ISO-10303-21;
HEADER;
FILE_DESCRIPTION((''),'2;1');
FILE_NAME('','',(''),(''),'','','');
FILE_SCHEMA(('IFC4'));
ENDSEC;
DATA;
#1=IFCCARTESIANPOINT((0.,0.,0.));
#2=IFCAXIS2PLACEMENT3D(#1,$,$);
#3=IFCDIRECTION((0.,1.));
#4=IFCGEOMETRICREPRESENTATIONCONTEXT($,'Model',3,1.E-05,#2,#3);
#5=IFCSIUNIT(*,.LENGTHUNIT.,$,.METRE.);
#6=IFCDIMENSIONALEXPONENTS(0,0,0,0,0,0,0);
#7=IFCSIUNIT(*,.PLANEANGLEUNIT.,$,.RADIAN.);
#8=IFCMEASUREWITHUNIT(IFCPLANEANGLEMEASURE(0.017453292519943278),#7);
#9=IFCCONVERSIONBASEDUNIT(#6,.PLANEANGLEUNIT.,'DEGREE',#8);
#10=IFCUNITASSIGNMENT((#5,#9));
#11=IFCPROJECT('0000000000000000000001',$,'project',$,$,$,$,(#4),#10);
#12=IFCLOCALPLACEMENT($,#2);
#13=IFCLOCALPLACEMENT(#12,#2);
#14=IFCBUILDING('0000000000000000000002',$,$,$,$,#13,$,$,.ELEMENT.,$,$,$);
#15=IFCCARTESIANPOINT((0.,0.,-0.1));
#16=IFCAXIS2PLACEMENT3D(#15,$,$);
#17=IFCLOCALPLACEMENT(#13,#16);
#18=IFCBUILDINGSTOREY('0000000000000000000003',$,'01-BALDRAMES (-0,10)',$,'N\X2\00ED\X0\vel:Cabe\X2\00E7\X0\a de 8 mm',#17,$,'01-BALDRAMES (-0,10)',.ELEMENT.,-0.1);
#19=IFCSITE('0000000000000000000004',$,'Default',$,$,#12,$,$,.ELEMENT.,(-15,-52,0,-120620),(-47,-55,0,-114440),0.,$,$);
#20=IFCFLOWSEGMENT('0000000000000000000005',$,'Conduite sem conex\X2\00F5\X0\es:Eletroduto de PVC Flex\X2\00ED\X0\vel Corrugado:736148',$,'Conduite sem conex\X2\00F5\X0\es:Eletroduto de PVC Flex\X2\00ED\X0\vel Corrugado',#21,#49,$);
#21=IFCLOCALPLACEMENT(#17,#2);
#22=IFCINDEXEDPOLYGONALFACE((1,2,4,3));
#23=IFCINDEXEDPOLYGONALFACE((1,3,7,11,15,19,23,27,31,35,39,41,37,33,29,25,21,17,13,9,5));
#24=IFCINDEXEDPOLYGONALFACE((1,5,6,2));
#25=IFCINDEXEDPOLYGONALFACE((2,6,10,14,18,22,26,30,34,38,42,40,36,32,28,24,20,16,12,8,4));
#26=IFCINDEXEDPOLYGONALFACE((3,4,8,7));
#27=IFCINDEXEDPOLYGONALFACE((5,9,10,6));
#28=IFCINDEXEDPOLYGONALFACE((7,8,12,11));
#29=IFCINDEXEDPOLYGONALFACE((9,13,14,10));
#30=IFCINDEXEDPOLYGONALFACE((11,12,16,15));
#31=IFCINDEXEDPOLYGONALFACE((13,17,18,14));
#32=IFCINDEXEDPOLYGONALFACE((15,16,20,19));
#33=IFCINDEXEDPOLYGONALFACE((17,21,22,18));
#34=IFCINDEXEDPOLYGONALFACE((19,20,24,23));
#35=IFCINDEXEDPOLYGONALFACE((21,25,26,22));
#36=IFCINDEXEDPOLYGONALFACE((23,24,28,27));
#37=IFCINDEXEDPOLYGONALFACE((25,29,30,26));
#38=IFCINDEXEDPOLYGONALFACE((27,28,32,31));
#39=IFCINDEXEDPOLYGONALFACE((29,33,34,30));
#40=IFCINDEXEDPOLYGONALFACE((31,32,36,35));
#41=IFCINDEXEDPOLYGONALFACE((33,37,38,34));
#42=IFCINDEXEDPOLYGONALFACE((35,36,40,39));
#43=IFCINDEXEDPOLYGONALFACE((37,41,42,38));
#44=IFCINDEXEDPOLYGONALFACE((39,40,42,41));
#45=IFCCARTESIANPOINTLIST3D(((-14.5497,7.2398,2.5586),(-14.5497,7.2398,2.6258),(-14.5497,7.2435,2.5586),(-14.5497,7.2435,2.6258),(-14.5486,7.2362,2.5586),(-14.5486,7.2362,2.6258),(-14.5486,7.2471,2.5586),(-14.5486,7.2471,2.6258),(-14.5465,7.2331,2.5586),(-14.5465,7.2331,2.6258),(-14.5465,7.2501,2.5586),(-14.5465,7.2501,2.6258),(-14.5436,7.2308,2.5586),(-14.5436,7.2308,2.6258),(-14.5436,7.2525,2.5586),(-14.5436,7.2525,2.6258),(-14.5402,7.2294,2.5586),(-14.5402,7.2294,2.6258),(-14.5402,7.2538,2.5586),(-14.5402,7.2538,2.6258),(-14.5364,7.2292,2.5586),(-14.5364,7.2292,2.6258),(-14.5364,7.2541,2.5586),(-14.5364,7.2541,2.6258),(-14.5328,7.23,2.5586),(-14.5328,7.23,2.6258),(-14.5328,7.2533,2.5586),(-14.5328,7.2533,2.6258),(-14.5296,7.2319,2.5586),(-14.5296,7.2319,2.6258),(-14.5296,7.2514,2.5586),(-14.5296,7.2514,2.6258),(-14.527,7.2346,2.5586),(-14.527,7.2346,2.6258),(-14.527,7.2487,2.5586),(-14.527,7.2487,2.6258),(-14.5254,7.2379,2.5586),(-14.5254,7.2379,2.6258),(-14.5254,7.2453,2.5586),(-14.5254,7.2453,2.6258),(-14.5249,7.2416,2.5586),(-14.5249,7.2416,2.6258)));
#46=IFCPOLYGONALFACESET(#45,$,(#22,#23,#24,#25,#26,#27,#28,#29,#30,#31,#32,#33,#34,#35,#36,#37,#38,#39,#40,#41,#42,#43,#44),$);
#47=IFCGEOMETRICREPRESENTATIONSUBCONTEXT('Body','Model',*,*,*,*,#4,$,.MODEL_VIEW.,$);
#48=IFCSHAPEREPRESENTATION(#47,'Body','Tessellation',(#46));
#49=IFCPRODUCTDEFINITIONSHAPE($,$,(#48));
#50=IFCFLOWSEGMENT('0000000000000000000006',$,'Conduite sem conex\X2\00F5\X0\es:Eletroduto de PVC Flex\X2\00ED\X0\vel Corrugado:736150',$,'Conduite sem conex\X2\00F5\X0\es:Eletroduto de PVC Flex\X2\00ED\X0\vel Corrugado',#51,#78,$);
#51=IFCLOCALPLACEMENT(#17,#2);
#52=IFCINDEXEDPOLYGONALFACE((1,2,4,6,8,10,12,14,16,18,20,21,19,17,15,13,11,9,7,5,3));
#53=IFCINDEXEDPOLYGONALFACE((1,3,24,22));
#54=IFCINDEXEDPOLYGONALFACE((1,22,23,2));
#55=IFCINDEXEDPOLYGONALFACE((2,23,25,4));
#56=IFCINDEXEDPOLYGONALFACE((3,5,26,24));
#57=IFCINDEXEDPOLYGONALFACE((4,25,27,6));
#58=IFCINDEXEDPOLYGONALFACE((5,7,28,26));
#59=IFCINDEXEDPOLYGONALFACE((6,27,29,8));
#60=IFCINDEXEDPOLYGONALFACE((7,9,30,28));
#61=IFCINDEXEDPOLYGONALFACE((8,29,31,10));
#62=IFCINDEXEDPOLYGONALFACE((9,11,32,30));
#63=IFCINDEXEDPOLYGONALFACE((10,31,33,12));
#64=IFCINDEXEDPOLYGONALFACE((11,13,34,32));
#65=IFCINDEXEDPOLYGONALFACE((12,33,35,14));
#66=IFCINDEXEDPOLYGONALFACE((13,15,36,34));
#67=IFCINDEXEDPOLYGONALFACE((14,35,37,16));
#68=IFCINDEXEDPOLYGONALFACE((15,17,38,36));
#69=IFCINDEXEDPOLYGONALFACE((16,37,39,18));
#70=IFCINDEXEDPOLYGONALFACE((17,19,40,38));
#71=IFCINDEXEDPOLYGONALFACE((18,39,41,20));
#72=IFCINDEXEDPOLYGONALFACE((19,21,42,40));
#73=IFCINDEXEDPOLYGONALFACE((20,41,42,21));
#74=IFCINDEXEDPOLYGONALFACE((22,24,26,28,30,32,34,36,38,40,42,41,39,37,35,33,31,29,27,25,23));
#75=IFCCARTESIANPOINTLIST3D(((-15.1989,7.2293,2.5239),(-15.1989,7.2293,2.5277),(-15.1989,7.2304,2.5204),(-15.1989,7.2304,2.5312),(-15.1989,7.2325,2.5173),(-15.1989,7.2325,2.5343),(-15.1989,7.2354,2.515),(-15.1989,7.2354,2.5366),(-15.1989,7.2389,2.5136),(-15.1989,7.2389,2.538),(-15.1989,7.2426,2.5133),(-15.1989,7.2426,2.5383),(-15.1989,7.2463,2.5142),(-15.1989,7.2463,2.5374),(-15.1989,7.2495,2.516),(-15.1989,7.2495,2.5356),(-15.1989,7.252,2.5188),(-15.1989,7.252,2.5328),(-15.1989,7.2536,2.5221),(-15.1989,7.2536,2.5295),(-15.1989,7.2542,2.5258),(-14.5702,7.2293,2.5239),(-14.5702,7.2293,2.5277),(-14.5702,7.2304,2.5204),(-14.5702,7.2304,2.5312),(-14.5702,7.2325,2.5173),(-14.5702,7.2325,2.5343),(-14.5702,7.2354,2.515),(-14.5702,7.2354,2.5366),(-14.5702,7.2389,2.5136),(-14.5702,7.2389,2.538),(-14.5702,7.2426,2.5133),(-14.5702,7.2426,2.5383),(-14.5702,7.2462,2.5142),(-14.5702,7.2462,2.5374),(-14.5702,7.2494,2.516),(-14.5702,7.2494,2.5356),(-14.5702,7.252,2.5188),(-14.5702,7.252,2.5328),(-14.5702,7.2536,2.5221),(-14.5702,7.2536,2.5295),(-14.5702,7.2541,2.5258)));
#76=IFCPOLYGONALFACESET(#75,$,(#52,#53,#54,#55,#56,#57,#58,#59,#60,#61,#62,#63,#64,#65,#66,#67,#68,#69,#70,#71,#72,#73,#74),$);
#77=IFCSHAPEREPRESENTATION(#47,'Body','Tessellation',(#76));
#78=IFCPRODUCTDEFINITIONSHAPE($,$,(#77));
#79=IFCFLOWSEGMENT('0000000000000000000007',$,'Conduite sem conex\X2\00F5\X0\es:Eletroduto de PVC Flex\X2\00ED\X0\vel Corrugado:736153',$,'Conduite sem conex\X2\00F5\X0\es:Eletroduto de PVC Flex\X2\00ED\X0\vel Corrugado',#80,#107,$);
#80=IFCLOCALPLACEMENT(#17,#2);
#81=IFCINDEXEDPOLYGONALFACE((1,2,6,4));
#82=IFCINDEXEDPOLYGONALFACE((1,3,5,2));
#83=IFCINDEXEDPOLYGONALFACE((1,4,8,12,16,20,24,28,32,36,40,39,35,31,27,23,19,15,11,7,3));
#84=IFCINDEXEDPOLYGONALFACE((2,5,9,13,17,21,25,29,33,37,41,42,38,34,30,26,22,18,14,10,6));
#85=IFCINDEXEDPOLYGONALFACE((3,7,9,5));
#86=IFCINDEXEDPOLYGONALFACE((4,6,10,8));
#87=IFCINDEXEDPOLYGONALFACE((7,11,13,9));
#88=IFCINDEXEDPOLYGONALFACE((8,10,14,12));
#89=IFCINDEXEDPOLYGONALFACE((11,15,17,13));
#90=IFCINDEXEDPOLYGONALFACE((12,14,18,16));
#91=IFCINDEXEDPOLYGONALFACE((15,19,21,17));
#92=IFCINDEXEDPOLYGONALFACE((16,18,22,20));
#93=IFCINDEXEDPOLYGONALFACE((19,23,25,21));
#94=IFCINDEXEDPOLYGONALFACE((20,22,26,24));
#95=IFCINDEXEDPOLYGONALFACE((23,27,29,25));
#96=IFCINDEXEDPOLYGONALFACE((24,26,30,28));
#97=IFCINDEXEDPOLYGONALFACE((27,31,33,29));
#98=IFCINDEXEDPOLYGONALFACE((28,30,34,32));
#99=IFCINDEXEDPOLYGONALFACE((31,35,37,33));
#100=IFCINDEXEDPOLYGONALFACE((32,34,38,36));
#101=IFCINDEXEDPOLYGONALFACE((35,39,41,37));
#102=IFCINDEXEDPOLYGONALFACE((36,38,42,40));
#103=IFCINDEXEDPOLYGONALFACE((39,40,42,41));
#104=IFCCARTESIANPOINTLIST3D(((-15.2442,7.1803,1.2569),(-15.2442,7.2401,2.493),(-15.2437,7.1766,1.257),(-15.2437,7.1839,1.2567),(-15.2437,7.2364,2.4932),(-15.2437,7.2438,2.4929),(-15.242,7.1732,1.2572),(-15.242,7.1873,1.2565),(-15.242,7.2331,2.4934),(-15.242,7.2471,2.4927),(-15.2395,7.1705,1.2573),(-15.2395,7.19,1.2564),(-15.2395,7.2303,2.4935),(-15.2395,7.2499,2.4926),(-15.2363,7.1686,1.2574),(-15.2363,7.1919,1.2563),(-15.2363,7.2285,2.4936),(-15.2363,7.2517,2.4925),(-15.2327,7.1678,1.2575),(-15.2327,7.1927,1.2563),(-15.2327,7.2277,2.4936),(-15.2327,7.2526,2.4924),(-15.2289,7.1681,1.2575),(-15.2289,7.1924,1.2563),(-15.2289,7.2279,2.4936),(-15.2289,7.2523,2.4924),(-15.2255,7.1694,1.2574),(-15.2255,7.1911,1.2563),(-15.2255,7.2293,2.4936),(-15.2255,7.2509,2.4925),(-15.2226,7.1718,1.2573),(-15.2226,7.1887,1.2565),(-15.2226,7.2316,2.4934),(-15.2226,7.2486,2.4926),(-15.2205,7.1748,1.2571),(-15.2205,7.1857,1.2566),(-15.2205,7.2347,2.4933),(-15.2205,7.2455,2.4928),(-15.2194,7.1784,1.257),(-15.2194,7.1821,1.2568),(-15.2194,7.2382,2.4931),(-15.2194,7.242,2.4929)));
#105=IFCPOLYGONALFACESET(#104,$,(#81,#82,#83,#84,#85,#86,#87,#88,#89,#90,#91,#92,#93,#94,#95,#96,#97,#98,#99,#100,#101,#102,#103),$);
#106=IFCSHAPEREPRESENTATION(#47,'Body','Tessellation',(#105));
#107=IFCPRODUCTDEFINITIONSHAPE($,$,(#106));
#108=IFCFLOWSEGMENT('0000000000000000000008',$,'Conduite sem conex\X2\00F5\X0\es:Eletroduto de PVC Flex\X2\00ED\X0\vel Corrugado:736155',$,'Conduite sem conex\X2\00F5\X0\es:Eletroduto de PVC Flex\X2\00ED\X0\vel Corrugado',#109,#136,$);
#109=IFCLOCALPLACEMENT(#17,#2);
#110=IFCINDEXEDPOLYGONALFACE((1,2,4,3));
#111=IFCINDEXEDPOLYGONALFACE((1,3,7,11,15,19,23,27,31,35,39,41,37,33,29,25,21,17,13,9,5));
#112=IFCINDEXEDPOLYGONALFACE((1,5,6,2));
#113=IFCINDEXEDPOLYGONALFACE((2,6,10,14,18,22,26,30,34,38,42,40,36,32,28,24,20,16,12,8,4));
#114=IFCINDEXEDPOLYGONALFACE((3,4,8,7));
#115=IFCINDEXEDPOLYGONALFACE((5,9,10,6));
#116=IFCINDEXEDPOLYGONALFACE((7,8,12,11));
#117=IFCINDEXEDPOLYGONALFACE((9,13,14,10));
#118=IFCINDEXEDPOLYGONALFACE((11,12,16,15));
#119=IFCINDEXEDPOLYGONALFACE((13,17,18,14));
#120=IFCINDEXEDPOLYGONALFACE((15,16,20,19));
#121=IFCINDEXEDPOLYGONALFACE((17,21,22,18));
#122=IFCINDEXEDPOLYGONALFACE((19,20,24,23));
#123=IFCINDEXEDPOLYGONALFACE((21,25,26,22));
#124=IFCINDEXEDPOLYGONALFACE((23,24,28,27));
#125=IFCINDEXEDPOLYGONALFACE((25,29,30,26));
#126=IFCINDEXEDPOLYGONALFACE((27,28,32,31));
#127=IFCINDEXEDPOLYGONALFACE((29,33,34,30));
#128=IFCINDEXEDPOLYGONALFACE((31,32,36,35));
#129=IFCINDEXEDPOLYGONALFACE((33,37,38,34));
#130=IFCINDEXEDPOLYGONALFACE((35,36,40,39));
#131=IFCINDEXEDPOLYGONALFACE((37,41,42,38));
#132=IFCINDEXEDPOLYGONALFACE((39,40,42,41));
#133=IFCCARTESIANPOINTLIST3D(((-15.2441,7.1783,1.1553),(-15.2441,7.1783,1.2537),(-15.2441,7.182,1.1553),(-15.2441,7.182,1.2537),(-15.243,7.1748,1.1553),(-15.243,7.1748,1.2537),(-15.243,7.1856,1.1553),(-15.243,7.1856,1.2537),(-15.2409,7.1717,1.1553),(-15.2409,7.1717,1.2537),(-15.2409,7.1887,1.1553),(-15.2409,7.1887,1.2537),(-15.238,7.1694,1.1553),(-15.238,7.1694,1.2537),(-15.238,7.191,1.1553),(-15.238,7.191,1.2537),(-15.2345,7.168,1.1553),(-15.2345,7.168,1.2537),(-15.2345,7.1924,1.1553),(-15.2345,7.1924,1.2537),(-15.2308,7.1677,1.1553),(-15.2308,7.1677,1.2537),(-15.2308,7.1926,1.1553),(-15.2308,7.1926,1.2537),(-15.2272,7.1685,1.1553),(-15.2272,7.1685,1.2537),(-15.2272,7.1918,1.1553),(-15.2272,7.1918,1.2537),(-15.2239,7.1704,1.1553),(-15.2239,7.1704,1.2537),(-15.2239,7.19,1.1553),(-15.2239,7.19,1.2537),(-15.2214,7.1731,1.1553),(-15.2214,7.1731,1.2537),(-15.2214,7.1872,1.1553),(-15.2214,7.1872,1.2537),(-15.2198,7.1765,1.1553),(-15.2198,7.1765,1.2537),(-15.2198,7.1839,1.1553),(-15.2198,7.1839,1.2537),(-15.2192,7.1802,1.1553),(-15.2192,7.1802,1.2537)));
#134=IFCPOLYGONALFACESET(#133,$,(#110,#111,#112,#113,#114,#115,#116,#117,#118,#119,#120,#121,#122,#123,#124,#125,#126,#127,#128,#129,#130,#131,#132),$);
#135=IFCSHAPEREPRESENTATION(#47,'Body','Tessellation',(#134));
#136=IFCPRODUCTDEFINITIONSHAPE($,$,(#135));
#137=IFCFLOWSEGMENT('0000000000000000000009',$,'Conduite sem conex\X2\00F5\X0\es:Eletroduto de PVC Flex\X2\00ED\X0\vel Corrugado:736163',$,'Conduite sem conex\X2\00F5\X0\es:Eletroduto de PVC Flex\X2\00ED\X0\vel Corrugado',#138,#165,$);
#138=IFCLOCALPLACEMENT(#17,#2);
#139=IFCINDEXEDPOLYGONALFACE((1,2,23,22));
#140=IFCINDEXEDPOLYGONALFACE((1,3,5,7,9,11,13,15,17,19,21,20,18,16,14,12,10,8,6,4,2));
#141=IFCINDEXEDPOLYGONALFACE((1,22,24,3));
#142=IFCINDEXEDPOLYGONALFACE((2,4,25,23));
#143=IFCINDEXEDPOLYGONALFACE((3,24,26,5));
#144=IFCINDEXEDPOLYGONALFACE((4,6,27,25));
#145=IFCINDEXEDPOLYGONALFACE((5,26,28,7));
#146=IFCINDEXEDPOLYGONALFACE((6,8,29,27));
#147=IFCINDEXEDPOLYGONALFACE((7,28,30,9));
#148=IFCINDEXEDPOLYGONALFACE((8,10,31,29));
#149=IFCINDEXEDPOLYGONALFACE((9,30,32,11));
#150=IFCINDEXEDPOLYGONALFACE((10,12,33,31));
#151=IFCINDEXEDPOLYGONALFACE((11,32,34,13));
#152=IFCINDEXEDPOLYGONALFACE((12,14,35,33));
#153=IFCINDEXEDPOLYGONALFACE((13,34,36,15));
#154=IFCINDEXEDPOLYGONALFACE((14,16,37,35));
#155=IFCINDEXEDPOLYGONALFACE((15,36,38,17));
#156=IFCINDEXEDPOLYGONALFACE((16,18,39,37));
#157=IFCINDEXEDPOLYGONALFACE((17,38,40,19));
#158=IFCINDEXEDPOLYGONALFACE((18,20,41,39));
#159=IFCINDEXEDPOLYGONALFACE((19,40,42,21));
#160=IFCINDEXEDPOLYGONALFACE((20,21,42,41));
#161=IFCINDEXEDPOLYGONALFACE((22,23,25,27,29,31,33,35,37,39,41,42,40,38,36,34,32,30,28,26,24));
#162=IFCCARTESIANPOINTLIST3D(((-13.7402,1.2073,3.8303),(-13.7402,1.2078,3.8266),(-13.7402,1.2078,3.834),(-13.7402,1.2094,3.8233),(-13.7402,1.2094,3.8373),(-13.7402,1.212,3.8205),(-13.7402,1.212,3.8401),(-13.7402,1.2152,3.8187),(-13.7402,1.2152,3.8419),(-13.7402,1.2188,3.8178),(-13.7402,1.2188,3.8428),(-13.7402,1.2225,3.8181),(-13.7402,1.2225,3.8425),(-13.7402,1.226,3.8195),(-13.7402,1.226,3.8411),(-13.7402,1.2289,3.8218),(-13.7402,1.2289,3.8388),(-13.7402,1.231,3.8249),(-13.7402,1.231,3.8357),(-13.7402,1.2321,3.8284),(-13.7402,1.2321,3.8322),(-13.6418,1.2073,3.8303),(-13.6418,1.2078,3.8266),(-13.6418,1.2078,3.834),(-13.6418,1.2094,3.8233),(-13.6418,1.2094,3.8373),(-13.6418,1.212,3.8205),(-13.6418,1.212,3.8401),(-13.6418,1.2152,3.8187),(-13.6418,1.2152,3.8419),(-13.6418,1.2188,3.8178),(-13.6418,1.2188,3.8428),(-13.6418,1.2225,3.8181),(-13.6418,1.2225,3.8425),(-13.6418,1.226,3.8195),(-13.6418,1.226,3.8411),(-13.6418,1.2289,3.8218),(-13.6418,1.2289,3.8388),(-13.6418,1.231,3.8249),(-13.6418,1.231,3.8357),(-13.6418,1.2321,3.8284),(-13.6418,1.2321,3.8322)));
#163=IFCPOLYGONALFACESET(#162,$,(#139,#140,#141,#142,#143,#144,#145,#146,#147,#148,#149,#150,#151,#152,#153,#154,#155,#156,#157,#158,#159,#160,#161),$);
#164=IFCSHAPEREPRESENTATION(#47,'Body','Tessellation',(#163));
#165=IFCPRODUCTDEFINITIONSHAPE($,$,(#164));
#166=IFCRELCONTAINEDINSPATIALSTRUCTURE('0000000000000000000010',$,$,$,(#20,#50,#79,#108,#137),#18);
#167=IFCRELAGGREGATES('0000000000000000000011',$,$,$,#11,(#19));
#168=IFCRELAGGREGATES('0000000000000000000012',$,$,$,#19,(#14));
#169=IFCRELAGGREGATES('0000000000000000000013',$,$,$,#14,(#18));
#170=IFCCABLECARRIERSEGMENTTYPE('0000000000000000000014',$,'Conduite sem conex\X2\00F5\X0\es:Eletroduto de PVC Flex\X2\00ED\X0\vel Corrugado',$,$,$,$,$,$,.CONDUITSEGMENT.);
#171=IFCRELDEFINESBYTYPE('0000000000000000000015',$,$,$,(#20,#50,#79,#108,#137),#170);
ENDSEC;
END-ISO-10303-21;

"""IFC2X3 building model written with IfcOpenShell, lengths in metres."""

from ifc_helpers import new_model, entity, si_unit, converted_unit, direction, frame, frame_2d, origin, origin_2d_with_axis, place, context, subcontext, project, spatial, circle, extrude, type_object, element, save


model = new_model("IFC2X3")

# Units and contexts
model_context = context("Model", 3, precision=1e-05, world=origin(), true_north=direction((0.0, 1.0)))
body_context = subcontext(model_context, "Body", "Model", "MODEL_VIEW")
ifc_project = project(units=[si_unit("LENGTHUNIT", "METRE"), converted_unit("PLANEANGLEUNIT", "DEGREE", entity("IfcPlaneAngleMeasure", 0.017453292519943278), si_unit("PLANEANGLEUNIT", "RADIAN"), dimensions=[0, 0, 0, 0, 0, 0, 0])], contexts=[model_context])

# Site, building, storey
site_placement = place(None, origin())
site = spatial("IfcSite", under=ifc_project, at=site_placement, Name="Default", CompositionType="ELEMENT", RefLatitude=(-15, -52, 0, -120620), RefLongitude=(-47, -55, 0, -114440), RefElevation=0.0)
building_placement = place(site_placement, origin())
building = spatial("IfcBuilding", under=site, at=building_placement, CompositionType="ELEMENT")
storey_placement = place(building_placement, frame((0.0, 0.0, -0.1)))
storey = spatial("IfcBuildingStorey", under=building, at=storey_placement, Name="01-BALDRAMES (-0,10)", ObjectType="Nível:Cabeça de 8 mm", LongName="01-BALDRAMES (-0,10)", CompositionType="ELEMENT", Elevation=-0.1)

# Flow segments
cable_carrier_segment_type = type_object("IfcCableCarrierSegmentType", Name="Conduite sem conexões:Eletroduto de PVC Flexível Corrugado", PredefinedType="CONDUITSEGMENT")
flow_segment_1_placement = place(storey_placement, origin())
element("IfcFlowSegment", 1, at=flow_segment_1_placement, inside=storey, type_object=cable_carrier_segment_type, Name="Conduite sem conexões:Eletroduto de PVC Flexível Corrugado:736148", ObjectType="Conduite sem conexões:Eletroduto de PVC Flexível Corrugado", context=body_context, shape_type="SweptSolid", body=[
    extrude(circle(Radius=0.0125, at=frame_2d((0.0, 0.0), x_axis=(1.0, 0.0))), frame((-14.5374, 7.2416, 2.5586)), (0.0, 0.0, 1.0), 0.0672),
])
flow_segment_2_placement = place(storey_placement, origin())
element("IfcFlowSegment", 2, at=flow_segment_2_placement, inside=storey, type_object=cable_carrier_segment_type, Name="Conduite sem conexões:Eletroduto de PVC Flexível Corrugado:736150", ObjectType="Conduite sem conexões:Eletroduto de PVC Flexível Corrugado", context=body_context, shape_type="SweptSolid", body=[
    extrude(circle(Radius=0.0125, at=frame_2d((0.0, 0.0), x_axis=(1.0, 0.0))), frame((-15.1989, 7.2417, 2.5258), z_axis=(1.0, -0.000085, 0.0), x_axis=(0.000085, 1.0, 0.0)), (0.0, 0.0, 1.0), 0.6287),
])
flow_segment_3_placement = place(storey_placement, origin())
element("IfcFlowSegment", 3, at=flow_segment_3_placement, inside=storey, type_object=cable_carrier_segment_type, Name="Conduite sem conexões:Eletroduto de PVC Flexível Corrugado:736153", ObjectType="Conduite sem conexões:Eletroduto de PVC Flexível Corrugado", context=body_context, shape_type="SweptSolid", body=[
    extrude(circle(Radius=0.0125, at=frame_2d((0.0, 0.0), x_axis=(1.0, 0.0))), frame((-15.2317, 7.1803, 1.2569), z_axis=(0.0, 0.048359, 0.99883), x_axis=(-1.0, 0.0, 0.0)), (0.0, 0.0, 1.0), 1.2376),
])
flow_segment_4_placement = place(storey_placement, origin())
element("IfcFlowSegment", 4, at=flow_segment_4_placement, inside=storey, type_object=cable_carrier_segment_type, Name="Conduite sem conexões:Eletroduto de PVC Flexível Corrugado:736155", ObjectType="Conduite sem conexões:Eletroduto de PVC Flexível Corrugado", context=body_context, shape_type="SweptSolid", body=[
    extrude(circle(Radius=0.0125, at=frame_2d((0.0, 0.0), x_axis=(1.0, 0.0))), frame((-15.2317, 7.1802, 1.1553)), (0.0, 0.0, 1.0), 0.0984),
])
flow_segment_5_placement = place(storey_placement, origin())
element("IfcFlowSegment", 5, at=flow_segment_5_placement, inside=storey, type_object=cable_carrier_segment_type, Name="Conduite sem conexões:Eletroduto de PVC Flexível Corrugado:736163", ObjectType="Conduite sem conexões:Eletroduto de PVC Flexível Corrugado", context=body_context, shape_type="SweptSolid", body=[
    extrude(circle(Radius=0.0125, at=origin_2d_with_axis()), frame((-13.7402, 1.2198, 3.8303), z_axis=(1.0, 0.0, 0.0), x_axis=(0.0, -1.0, 0.0)), (0.0, 0.0, 1.0), 0.0984),
])

save(model, "model.ifc")
